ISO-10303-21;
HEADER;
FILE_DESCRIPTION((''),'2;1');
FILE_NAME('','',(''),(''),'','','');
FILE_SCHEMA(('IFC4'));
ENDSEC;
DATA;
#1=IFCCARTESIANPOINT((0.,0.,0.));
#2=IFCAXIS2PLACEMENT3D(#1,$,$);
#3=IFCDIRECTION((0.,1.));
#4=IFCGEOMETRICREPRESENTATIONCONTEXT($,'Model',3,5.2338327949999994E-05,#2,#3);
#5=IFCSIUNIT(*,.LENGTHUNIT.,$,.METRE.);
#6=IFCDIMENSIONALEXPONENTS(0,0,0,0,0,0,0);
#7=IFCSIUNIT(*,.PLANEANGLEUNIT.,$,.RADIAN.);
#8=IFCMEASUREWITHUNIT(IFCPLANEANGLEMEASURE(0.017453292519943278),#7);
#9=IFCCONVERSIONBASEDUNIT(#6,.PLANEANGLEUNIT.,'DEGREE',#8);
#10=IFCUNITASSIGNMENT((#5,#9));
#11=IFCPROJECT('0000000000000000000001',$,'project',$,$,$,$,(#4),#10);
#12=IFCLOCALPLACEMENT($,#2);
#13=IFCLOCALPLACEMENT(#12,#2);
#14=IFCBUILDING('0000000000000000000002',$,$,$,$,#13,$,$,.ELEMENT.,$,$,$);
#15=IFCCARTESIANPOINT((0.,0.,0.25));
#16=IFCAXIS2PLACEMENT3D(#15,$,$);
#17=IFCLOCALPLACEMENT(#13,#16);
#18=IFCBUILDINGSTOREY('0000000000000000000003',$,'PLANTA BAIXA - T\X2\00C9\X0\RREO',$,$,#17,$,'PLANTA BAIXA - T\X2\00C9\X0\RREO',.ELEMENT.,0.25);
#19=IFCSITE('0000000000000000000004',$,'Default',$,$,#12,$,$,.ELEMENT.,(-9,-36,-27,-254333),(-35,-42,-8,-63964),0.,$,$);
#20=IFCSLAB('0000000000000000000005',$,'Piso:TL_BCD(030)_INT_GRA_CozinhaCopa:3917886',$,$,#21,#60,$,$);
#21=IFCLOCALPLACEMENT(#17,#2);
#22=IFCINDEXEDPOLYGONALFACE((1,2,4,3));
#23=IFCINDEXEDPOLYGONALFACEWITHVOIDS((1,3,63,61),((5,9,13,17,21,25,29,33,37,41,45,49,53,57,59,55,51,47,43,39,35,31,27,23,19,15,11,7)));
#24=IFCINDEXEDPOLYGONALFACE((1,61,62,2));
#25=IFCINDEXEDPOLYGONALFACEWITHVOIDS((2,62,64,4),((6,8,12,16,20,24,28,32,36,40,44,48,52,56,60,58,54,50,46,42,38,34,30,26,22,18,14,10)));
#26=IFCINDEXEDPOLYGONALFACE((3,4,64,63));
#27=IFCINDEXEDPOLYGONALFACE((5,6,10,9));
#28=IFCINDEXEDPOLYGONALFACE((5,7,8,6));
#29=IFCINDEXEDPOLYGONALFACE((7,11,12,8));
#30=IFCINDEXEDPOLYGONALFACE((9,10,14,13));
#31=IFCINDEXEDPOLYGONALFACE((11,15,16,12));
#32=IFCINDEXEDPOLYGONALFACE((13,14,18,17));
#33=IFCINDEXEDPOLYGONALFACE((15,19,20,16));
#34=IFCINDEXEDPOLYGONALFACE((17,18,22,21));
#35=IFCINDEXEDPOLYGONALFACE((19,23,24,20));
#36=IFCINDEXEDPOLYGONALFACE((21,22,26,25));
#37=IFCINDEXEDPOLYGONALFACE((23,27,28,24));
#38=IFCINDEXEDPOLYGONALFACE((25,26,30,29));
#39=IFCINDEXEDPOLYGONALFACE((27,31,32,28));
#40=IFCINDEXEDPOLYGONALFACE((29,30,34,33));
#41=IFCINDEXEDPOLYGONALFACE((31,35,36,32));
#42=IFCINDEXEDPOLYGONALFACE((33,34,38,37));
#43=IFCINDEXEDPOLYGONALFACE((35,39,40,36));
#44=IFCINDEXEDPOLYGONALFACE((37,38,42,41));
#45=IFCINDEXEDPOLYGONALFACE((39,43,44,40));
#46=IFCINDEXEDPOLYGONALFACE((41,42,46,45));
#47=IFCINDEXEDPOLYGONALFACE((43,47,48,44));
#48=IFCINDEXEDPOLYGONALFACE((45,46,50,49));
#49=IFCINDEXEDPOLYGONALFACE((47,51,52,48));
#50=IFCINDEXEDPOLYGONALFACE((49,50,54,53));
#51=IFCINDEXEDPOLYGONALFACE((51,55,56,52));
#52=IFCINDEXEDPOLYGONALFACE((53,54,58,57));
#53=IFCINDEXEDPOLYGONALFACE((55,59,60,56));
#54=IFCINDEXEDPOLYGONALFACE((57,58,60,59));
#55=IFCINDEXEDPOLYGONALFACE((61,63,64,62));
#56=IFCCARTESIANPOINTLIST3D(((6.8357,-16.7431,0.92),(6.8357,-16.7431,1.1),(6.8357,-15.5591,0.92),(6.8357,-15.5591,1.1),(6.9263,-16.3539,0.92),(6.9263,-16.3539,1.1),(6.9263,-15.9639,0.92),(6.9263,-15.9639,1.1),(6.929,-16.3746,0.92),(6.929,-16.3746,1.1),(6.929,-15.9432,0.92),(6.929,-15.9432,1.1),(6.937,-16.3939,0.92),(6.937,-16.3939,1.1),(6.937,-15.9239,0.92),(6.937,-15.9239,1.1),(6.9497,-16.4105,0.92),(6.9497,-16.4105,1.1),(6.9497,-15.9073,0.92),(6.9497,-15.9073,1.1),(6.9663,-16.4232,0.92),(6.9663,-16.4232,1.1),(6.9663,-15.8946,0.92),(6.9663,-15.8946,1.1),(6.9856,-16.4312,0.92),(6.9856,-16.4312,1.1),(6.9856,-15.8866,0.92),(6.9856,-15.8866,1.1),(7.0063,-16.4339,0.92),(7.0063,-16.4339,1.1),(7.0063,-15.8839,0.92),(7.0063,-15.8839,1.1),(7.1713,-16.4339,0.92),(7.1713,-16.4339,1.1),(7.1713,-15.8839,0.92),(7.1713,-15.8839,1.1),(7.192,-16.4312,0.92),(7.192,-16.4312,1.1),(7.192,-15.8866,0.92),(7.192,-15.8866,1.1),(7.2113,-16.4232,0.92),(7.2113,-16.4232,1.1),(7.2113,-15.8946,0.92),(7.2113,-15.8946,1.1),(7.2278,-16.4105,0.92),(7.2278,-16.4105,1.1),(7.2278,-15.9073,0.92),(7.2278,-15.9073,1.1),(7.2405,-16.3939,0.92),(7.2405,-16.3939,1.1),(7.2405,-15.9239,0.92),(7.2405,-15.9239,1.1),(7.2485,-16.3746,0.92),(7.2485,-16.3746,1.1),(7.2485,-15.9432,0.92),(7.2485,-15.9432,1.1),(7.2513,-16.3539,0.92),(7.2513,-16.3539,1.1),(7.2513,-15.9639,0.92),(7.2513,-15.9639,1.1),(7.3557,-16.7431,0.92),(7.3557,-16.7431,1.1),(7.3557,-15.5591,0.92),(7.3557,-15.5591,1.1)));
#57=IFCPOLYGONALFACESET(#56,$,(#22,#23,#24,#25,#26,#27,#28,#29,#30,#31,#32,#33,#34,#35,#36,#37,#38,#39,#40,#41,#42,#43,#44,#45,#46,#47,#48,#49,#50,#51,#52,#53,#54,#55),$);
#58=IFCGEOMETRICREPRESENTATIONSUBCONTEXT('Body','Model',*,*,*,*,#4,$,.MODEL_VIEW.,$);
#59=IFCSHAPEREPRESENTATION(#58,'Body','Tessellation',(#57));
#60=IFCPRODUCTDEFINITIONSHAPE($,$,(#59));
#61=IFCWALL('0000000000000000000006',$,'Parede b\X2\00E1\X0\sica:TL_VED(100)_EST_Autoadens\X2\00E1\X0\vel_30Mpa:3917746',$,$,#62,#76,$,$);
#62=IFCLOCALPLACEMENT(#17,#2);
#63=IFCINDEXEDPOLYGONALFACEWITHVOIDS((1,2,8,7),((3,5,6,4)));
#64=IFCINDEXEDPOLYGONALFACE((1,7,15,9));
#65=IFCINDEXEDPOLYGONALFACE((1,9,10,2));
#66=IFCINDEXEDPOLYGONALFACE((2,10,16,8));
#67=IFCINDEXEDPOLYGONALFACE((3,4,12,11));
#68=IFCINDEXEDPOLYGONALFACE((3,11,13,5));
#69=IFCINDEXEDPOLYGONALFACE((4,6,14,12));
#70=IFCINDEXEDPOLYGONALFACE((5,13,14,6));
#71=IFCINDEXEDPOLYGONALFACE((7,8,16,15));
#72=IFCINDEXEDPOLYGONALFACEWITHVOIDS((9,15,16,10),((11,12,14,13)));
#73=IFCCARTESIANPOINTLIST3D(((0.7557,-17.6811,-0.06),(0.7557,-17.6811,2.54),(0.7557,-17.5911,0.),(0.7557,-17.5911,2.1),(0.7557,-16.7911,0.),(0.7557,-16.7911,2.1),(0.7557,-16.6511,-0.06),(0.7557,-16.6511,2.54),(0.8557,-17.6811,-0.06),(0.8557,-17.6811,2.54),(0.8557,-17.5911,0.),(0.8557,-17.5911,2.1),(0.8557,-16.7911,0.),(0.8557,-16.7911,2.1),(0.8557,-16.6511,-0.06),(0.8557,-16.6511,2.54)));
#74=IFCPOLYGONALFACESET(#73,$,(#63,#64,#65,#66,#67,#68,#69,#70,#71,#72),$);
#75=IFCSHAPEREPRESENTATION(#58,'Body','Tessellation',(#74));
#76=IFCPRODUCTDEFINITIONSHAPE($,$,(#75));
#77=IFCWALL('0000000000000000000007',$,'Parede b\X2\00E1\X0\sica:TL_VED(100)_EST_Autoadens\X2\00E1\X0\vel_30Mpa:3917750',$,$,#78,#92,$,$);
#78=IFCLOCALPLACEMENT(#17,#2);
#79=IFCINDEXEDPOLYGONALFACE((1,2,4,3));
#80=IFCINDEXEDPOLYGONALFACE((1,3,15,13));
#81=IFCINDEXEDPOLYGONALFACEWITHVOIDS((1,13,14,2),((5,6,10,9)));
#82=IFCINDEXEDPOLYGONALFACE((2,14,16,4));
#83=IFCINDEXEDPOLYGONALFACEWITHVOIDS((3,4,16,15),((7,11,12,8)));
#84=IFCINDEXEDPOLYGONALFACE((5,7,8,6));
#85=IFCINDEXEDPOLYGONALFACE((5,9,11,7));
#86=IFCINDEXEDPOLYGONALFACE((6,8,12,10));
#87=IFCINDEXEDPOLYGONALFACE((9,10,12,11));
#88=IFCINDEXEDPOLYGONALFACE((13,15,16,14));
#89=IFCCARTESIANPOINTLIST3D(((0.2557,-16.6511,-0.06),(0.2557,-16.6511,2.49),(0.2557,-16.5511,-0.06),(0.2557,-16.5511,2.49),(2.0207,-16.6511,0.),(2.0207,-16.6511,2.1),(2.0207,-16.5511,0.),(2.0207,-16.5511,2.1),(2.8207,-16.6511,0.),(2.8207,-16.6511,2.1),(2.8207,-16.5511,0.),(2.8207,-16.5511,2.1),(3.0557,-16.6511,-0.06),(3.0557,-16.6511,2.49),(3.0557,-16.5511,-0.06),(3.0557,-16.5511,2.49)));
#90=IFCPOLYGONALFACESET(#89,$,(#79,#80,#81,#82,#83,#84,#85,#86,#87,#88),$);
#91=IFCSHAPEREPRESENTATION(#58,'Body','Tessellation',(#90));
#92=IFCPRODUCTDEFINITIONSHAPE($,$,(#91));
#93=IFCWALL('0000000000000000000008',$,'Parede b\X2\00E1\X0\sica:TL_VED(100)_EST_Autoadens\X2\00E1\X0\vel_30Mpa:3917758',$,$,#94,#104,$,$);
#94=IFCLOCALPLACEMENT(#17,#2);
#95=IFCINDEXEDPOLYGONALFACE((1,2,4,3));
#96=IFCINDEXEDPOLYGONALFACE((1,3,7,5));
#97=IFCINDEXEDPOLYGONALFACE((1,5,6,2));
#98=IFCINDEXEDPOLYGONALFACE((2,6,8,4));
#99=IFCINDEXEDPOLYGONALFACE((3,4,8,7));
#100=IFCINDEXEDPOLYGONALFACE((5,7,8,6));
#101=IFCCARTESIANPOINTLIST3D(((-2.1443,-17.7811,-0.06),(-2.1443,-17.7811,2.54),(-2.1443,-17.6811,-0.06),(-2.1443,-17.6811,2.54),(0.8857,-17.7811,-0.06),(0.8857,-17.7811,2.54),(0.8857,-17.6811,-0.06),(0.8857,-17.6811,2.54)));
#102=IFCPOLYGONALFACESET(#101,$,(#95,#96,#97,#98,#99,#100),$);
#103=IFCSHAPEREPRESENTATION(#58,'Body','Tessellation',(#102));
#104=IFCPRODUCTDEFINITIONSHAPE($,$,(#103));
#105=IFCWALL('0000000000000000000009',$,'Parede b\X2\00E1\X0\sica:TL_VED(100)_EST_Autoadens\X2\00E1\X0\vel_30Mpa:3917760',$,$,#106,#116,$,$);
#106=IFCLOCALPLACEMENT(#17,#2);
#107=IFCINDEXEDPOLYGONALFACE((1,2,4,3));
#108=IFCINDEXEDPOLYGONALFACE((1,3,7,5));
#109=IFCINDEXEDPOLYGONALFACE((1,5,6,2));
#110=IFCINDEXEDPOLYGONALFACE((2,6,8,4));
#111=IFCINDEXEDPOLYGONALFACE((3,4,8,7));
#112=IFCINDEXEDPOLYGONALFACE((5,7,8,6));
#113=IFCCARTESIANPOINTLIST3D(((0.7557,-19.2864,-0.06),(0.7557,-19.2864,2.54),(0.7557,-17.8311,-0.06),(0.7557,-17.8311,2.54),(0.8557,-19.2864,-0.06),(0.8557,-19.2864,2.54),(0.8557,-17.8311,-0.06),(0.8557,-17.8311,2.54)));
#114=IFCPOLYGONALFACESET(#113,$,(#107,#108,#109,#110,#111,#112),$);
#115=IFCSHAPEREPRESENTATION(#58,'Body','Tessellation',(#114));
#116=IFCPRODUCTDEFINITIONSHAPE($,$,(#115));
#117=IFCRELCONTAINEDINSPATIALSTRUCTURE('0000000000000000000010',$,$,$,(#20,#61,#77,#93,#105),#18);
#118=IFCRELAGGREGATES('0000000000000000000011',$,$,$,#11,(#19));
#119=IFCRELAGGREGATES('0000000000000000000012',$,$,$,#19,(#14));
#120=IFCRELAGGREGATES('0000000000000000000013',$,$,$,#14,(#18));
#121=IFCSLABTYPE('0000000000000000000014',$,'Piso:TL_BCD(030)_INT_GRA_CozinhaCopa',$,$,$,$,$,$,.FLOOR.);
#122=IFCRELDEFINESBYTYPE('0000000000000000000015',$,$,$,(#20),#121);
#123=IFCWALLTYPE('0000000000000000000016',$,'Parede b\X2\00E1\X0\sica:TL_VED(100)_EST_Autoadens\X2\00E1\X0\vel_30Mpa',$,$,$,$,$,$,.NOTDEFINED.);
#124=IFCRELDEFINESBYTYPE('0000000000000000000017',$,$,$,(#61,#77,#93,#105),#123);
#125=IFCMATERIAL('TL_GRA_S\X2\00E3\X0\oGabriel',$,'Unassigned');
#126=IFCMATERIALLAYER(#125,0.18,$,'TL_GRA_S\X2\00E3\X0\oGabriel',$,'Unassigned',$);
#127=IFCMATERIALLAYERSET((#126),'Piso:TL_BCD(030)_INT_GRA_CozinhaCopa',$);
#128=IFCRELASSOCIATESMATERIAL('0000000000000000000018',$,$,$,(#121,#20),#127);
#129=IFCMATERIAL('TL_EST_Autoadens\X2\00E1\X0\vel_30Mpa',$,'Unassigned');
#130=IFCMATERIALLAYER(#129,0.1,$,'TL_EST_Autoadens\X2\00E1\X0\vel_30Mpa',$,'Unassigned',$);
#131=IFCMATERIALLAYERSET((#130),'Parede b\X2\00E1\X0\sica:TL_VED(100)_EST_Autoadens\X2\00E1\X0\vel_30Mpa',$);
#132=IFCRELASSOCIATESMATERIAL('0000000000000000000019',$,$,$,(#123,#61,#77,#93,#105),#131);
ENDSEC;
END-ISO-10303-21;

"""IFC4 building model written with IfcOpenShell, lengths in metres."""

from ifc_helpers import new_model, entity, si_unit, converted_unit, direction, frame, frame_2d, origin, place, context, subcontext, project, spatial, polyline, circle_curve, parameter, trimmed, segment, composite_curve, rectangle, outline, extrude, material, layer, layer_set, layer_usage, type_object, element, save


model = new_model("IFC4")

# Units and contexts
model_context = context("Model", 3, precision=5.2338327949999994e-05, world=origin(), true_north=direction((0.0, 1.0)))
body_context = subcontext(model_context, "Body", "Model", "MODEL_VIEW")
ifc_project = project(units=[si_unit("LENGTHUNIT", "METRE"), converted_unit("PLANEANGLEUNIT", "DEGREE", entity("IfcPlaneAngleMeasure", 0.017453292519943278), si_unit("PLANEANGLEUNIT", "RADIAN"), dimensions=[0, 0, 0, 0, 0, 0, 0])], contexts=[model_context])

# Site, building, storey
site_placement = place(None, frame((0.0, 0.0, 0.0)))
site = spatial("IfcSite", under=ifc_project, at=site_placement, Name="Default", CompositionType="ELEMENT", RefLatitude=(-9, -36, -27, -254333), RefLongitude=(-35, -42, -8, -63964), RefElevation=0.0)
building_placement = place(site_placement, origin())
building = spatial("IfcBuilding", under=site, at=building_placement, CompositionType="ELEMENT")
storey_placement = place(building_placement, frame((0.0, 0.0, 0.25)))
storey = spatial("IfcBuildingStorey", under=building, at=storey_placement, Name="PLANTA BAIXA - TÉRREO", LongName="PLANTA BAIXA - TÉRREO", CompositionType="ELEMENT", Elevation=0.25)

# Slab, opening
ifc_material_1 = material(Name="TL_GRA_SãoGabriel", Category="Unassigned")
ifc_layer_1 = layer(ifc_material_1, 0.18, Name="TL_GRA_SãoGabriel", Category="Unassigned")
ifc_layer_set_1 = layer_set([ifc_layer_1], Name="Piso:TL_BCD(030)_INT_GRA_CozinhaCopa")
ifc_layer_usage_1 = layer_usage(ifc_layer_set_1, "AXIS3", "POSITIVE", 0.0)
slab_type = type_object("IfcSlabType", Name="Piso:TL_BCD(030)_INT_GRA_CozinhaCopa", PredefinedType="FLOOR", material=ifc_layer_set_1)
slab_placement = place(storey_placement, frame((6.8357, -16.7431, 0.92)))
slab = element("IfcSlab", 1, at=slab_placement, inside=storey, type_object=slab_type, material=ifc_layer_usage_1, Name="Piso:TL_BCD(030)_INT_GRA_CozinhaCopa:3917886", context=body_context, shape_type="SweptSolid", body=[
    extrude(rectangle(XDim=1.184, YDim=0.52, at=frame_2d((0.0, 0.0), x_axis=(0.0, -1.0))), frame((0.26, 0.592, 0.18), z_axis=(0.0, 0.0, -1.0), x_axis=(-1.0, 0.0, 0.0)), (0.0, 0.0, 1.0), 0.18),
])
opening_1_placement = place(slab_placement, frame((-6.8357, 16.7431, 0.18)))
element("IfcOpeningElement", 2, at=opening_1_placement, cuts=slab, PredefinedType="OPENING", context=body_context, shape_type="SweptSolid", body=[
    extrude(outline(composite_curve([segment(polyline([(-0.195, -0.1625), (0.195, -0.1625)]), True, "CONTINUOUS"), segment(trimmed(circle_curve(frame_2d((0.195, -0.0825), x_axis=(-1.0, 0.0)), 0.08), [parameter(90.0)], [parameter(180.0)], True, "PARAMETER"), True, "CONTINUOUS"), segment(polyline([(0.275, -0.0825), (0.275, 0.0825)]), True, "CONTINUOUS"), segment(trimmed(circle_curve(frame_2d((0.195, 0.0825), x_axis=(-1.0, 0.0)), 0.08), [parameter(180.0)], [parameter(270.0)], True, "PARAMETER"), True, "CONTINUOUS"), segment(polyline([(0.195, 0.1625), (-0.195, 0.1625)]), True, "CONTINUOUS"), segment(trimmed(circle_curve(frame_2d((-0.195, 0.0825), x_axis=(-1.0, 0.0)), 0.08), [parameter(270.0)], [parameter(360.0)], True, "PARAMETER"), True, "CONTINUOUS"), segment(polyline([(-0.275, 0.0825), (-0.275, -0.0825)]), True, "CONTINUOUS"), segment(trimmed(circle_curve(frame_2d((-0.195, -0.0825), x_axis=(-1.0, 0.0)), 0.08), [parameter(360.0)], [parameter(90.0)], True, "PARAMETER"), True, "CONTINUOUS")], self_intersect=False)), frame((7.0888, -16.1589, -0.21), z_axis=(0.0, 0.0, 1.0), x_axis=(0.0, 1.0, 0.0)), (0.0, 0.0, 1.0), 0.21),
])

# Walls, openings
ifc_material_2 = material(Name="TL_EST_Autoadensável_30Mpa", Category="Unassigned")
ifc_layer_2 = layer(ifc_material_2, 0.1, Name="TL_EST_Autoadensável_30Mpa", Category="Unassigned")
ifc_layer_set_2 = layer_set([ifc_layer_2], Name="Parede básica:TL_VED(100)_EST_Autoadensável_30Mpa")
ifc_layer_usage_2 = layer_usage(ifc_layer_set_2, "AXIS2", "POSITIVE", -0.05)
wall_type_1 = type_object("IfcWallType", Name="Parede básica:TL_VED(100)_EST_Autoadensável_30Mpa", PredefinedType="NOTDEFINED", material=ifc_layer_set_2)
wall_1_placement = place(storey_placement, frame((0.8057, -16.6511, -0.06), z_axis=(0.0, 0.0, 1.0), x_axis=(0.0, -1.0, 0.0)))
wall_1 = element("IfcWall", 3, at=wall_1_placement, inside=storey, type_object=wall_type_1, material=ifc_layer_usage_2, Name="Parede básica:TL_VED(100)_EST_Autoadensável_30Mpa:3917746", context=body_context, shape_type="SweptSolid", body=[
    extrude(rectangle(XDim=1.03, YDim=0.1, at=frame_2d((0.515, 0.0), x_axis=(-1.0, 0.0))), origin(), (0.0, 0.0, 1.0), 2.6),
])
opening_2_placement = place(wall_1_placement, frame((0.94, 0.05, 0.06)))
element("IfcOpeningElement", 4, at=opening_2_placement, cuts=wall_1, PredefinedType="OPENING", context=body_context, shape_type="SweptSolid", body=[
    extrude(rectangle(XDim=2.1, YDim=0.8, at=frame_2d((1.05, 0.4), x_axis=(1.0, 0.0))), frame((0.0, 0.0, 0.0), z_axis=(0.0, -1.0, 0.0), x_axis=(0.0, 0.0, 1.0)), (0.0, 0.0, 1.0), 0.1),
])
ifc_layer_usage_3 = layer_usage(ifc_layer_set_2, "AXIS2", "POSITIVE", -0.05)
wall_2_placement = place(storey_placement, frame((3.0557, -16.6011, -0.06), z_axis=(0.0, 0.0, 1.0), x_axis=(-1.0, 0.0, 0.0)))
wall_2 = element("IfcWall", 5, at=wall_2_placement, inside=storey, type_object=wall_type_1, material=ifc_layer_usage_3, Name="Parede básica:TL_VED(100)_EST_Autoadensável_30Mpa:3917750", context=body_context, shape_type="SweptSolid", body=[
    extrude(rectangle(XDim=2.8, YDim=0.1, at=frame_2d((1.4, 0.0), x_axis=(-1.0, 0.0))), origin(), (0.0, 0.0, 1.0), 2.55),
])
opening_3_placement = place(wall_2_placement, frame((1.035, 0.05, 0.06)))
element("IfcOpeningElement", 6, at=opening_3_placement, cuts=wall_2, PredefinedType="OPENING", context=body_context, shape_type="SweptSolid", body=[
    extrude(rectangle(XDim=2.1, YDim=0.8, at=frame_2d((1.05, 0.4), x_axis=(1.0, 0.0))), frame((0.0, 0.0, 0.0), z_axis=(0.0, -1.0, 0.0), x_axis=(0.0, 0.0, 1.0)), (0.0, 0.0, 1.0), 0.1),
])

# Walls
ifc_layer_usage_4 = layer_usage(ifc_layer_set_2, "AXIS2", "NEGATIVE", 0.05)
wall_3_placement = place(storey_placement, frame((0.8857, -17.7311, -0.06), z_axis=(0.0, 0.0, 1.0), x_axis=(-1.0, 0.0, 0.0)))
element("IfcWall", 7, at=wall_3_placement, inside=storey, type_object=wall_type_1, material=ifc_layer_usage_4, Name="Parede básica:TL_VED(100)_EST_Autoadensável_30Mpa:3917758", context=body_context, shape_type="SweptSolid", body=[
    extrude(rectangle(XDim=3.03, YDim=0.1, at=frame_2d((1.515, 0.0), x_axis=(-1.0, 0.0))), origin(), (0.0, 0.0, 1.0), 2.6),
])
ifc_layer_usage_5 = layer_usage(ifc_layer_set_2, "AXIS2", "POSITIVE", -0.05)
wall_4_placement = place(storey_placement, frame((0.8057, -19.2864, -0.06), z_axis=(0.0, 0.0, 1.0), x_axis=(0.0, 1.0, 0.0)))
element("IfcWall", 8, at=wall_4_placement, inside=storey, type_object=wall_type_1, material=ifc_layer_usage_5, Name="Parede básica:TL_VED(100)_EST_Autoadensável_30Mpa:3917760", context=body_context, shape_type="SweptSolid", body=[
    extrude(rectangle(XDim=1.4552, YDim=0.1, at=frame_2d((0.7276, 0.0), x_axis=(-1.0, 0.0))), origin(), (0.0, 0.0, 1.0), 2.6),
])

save(model, "model.ifc")
